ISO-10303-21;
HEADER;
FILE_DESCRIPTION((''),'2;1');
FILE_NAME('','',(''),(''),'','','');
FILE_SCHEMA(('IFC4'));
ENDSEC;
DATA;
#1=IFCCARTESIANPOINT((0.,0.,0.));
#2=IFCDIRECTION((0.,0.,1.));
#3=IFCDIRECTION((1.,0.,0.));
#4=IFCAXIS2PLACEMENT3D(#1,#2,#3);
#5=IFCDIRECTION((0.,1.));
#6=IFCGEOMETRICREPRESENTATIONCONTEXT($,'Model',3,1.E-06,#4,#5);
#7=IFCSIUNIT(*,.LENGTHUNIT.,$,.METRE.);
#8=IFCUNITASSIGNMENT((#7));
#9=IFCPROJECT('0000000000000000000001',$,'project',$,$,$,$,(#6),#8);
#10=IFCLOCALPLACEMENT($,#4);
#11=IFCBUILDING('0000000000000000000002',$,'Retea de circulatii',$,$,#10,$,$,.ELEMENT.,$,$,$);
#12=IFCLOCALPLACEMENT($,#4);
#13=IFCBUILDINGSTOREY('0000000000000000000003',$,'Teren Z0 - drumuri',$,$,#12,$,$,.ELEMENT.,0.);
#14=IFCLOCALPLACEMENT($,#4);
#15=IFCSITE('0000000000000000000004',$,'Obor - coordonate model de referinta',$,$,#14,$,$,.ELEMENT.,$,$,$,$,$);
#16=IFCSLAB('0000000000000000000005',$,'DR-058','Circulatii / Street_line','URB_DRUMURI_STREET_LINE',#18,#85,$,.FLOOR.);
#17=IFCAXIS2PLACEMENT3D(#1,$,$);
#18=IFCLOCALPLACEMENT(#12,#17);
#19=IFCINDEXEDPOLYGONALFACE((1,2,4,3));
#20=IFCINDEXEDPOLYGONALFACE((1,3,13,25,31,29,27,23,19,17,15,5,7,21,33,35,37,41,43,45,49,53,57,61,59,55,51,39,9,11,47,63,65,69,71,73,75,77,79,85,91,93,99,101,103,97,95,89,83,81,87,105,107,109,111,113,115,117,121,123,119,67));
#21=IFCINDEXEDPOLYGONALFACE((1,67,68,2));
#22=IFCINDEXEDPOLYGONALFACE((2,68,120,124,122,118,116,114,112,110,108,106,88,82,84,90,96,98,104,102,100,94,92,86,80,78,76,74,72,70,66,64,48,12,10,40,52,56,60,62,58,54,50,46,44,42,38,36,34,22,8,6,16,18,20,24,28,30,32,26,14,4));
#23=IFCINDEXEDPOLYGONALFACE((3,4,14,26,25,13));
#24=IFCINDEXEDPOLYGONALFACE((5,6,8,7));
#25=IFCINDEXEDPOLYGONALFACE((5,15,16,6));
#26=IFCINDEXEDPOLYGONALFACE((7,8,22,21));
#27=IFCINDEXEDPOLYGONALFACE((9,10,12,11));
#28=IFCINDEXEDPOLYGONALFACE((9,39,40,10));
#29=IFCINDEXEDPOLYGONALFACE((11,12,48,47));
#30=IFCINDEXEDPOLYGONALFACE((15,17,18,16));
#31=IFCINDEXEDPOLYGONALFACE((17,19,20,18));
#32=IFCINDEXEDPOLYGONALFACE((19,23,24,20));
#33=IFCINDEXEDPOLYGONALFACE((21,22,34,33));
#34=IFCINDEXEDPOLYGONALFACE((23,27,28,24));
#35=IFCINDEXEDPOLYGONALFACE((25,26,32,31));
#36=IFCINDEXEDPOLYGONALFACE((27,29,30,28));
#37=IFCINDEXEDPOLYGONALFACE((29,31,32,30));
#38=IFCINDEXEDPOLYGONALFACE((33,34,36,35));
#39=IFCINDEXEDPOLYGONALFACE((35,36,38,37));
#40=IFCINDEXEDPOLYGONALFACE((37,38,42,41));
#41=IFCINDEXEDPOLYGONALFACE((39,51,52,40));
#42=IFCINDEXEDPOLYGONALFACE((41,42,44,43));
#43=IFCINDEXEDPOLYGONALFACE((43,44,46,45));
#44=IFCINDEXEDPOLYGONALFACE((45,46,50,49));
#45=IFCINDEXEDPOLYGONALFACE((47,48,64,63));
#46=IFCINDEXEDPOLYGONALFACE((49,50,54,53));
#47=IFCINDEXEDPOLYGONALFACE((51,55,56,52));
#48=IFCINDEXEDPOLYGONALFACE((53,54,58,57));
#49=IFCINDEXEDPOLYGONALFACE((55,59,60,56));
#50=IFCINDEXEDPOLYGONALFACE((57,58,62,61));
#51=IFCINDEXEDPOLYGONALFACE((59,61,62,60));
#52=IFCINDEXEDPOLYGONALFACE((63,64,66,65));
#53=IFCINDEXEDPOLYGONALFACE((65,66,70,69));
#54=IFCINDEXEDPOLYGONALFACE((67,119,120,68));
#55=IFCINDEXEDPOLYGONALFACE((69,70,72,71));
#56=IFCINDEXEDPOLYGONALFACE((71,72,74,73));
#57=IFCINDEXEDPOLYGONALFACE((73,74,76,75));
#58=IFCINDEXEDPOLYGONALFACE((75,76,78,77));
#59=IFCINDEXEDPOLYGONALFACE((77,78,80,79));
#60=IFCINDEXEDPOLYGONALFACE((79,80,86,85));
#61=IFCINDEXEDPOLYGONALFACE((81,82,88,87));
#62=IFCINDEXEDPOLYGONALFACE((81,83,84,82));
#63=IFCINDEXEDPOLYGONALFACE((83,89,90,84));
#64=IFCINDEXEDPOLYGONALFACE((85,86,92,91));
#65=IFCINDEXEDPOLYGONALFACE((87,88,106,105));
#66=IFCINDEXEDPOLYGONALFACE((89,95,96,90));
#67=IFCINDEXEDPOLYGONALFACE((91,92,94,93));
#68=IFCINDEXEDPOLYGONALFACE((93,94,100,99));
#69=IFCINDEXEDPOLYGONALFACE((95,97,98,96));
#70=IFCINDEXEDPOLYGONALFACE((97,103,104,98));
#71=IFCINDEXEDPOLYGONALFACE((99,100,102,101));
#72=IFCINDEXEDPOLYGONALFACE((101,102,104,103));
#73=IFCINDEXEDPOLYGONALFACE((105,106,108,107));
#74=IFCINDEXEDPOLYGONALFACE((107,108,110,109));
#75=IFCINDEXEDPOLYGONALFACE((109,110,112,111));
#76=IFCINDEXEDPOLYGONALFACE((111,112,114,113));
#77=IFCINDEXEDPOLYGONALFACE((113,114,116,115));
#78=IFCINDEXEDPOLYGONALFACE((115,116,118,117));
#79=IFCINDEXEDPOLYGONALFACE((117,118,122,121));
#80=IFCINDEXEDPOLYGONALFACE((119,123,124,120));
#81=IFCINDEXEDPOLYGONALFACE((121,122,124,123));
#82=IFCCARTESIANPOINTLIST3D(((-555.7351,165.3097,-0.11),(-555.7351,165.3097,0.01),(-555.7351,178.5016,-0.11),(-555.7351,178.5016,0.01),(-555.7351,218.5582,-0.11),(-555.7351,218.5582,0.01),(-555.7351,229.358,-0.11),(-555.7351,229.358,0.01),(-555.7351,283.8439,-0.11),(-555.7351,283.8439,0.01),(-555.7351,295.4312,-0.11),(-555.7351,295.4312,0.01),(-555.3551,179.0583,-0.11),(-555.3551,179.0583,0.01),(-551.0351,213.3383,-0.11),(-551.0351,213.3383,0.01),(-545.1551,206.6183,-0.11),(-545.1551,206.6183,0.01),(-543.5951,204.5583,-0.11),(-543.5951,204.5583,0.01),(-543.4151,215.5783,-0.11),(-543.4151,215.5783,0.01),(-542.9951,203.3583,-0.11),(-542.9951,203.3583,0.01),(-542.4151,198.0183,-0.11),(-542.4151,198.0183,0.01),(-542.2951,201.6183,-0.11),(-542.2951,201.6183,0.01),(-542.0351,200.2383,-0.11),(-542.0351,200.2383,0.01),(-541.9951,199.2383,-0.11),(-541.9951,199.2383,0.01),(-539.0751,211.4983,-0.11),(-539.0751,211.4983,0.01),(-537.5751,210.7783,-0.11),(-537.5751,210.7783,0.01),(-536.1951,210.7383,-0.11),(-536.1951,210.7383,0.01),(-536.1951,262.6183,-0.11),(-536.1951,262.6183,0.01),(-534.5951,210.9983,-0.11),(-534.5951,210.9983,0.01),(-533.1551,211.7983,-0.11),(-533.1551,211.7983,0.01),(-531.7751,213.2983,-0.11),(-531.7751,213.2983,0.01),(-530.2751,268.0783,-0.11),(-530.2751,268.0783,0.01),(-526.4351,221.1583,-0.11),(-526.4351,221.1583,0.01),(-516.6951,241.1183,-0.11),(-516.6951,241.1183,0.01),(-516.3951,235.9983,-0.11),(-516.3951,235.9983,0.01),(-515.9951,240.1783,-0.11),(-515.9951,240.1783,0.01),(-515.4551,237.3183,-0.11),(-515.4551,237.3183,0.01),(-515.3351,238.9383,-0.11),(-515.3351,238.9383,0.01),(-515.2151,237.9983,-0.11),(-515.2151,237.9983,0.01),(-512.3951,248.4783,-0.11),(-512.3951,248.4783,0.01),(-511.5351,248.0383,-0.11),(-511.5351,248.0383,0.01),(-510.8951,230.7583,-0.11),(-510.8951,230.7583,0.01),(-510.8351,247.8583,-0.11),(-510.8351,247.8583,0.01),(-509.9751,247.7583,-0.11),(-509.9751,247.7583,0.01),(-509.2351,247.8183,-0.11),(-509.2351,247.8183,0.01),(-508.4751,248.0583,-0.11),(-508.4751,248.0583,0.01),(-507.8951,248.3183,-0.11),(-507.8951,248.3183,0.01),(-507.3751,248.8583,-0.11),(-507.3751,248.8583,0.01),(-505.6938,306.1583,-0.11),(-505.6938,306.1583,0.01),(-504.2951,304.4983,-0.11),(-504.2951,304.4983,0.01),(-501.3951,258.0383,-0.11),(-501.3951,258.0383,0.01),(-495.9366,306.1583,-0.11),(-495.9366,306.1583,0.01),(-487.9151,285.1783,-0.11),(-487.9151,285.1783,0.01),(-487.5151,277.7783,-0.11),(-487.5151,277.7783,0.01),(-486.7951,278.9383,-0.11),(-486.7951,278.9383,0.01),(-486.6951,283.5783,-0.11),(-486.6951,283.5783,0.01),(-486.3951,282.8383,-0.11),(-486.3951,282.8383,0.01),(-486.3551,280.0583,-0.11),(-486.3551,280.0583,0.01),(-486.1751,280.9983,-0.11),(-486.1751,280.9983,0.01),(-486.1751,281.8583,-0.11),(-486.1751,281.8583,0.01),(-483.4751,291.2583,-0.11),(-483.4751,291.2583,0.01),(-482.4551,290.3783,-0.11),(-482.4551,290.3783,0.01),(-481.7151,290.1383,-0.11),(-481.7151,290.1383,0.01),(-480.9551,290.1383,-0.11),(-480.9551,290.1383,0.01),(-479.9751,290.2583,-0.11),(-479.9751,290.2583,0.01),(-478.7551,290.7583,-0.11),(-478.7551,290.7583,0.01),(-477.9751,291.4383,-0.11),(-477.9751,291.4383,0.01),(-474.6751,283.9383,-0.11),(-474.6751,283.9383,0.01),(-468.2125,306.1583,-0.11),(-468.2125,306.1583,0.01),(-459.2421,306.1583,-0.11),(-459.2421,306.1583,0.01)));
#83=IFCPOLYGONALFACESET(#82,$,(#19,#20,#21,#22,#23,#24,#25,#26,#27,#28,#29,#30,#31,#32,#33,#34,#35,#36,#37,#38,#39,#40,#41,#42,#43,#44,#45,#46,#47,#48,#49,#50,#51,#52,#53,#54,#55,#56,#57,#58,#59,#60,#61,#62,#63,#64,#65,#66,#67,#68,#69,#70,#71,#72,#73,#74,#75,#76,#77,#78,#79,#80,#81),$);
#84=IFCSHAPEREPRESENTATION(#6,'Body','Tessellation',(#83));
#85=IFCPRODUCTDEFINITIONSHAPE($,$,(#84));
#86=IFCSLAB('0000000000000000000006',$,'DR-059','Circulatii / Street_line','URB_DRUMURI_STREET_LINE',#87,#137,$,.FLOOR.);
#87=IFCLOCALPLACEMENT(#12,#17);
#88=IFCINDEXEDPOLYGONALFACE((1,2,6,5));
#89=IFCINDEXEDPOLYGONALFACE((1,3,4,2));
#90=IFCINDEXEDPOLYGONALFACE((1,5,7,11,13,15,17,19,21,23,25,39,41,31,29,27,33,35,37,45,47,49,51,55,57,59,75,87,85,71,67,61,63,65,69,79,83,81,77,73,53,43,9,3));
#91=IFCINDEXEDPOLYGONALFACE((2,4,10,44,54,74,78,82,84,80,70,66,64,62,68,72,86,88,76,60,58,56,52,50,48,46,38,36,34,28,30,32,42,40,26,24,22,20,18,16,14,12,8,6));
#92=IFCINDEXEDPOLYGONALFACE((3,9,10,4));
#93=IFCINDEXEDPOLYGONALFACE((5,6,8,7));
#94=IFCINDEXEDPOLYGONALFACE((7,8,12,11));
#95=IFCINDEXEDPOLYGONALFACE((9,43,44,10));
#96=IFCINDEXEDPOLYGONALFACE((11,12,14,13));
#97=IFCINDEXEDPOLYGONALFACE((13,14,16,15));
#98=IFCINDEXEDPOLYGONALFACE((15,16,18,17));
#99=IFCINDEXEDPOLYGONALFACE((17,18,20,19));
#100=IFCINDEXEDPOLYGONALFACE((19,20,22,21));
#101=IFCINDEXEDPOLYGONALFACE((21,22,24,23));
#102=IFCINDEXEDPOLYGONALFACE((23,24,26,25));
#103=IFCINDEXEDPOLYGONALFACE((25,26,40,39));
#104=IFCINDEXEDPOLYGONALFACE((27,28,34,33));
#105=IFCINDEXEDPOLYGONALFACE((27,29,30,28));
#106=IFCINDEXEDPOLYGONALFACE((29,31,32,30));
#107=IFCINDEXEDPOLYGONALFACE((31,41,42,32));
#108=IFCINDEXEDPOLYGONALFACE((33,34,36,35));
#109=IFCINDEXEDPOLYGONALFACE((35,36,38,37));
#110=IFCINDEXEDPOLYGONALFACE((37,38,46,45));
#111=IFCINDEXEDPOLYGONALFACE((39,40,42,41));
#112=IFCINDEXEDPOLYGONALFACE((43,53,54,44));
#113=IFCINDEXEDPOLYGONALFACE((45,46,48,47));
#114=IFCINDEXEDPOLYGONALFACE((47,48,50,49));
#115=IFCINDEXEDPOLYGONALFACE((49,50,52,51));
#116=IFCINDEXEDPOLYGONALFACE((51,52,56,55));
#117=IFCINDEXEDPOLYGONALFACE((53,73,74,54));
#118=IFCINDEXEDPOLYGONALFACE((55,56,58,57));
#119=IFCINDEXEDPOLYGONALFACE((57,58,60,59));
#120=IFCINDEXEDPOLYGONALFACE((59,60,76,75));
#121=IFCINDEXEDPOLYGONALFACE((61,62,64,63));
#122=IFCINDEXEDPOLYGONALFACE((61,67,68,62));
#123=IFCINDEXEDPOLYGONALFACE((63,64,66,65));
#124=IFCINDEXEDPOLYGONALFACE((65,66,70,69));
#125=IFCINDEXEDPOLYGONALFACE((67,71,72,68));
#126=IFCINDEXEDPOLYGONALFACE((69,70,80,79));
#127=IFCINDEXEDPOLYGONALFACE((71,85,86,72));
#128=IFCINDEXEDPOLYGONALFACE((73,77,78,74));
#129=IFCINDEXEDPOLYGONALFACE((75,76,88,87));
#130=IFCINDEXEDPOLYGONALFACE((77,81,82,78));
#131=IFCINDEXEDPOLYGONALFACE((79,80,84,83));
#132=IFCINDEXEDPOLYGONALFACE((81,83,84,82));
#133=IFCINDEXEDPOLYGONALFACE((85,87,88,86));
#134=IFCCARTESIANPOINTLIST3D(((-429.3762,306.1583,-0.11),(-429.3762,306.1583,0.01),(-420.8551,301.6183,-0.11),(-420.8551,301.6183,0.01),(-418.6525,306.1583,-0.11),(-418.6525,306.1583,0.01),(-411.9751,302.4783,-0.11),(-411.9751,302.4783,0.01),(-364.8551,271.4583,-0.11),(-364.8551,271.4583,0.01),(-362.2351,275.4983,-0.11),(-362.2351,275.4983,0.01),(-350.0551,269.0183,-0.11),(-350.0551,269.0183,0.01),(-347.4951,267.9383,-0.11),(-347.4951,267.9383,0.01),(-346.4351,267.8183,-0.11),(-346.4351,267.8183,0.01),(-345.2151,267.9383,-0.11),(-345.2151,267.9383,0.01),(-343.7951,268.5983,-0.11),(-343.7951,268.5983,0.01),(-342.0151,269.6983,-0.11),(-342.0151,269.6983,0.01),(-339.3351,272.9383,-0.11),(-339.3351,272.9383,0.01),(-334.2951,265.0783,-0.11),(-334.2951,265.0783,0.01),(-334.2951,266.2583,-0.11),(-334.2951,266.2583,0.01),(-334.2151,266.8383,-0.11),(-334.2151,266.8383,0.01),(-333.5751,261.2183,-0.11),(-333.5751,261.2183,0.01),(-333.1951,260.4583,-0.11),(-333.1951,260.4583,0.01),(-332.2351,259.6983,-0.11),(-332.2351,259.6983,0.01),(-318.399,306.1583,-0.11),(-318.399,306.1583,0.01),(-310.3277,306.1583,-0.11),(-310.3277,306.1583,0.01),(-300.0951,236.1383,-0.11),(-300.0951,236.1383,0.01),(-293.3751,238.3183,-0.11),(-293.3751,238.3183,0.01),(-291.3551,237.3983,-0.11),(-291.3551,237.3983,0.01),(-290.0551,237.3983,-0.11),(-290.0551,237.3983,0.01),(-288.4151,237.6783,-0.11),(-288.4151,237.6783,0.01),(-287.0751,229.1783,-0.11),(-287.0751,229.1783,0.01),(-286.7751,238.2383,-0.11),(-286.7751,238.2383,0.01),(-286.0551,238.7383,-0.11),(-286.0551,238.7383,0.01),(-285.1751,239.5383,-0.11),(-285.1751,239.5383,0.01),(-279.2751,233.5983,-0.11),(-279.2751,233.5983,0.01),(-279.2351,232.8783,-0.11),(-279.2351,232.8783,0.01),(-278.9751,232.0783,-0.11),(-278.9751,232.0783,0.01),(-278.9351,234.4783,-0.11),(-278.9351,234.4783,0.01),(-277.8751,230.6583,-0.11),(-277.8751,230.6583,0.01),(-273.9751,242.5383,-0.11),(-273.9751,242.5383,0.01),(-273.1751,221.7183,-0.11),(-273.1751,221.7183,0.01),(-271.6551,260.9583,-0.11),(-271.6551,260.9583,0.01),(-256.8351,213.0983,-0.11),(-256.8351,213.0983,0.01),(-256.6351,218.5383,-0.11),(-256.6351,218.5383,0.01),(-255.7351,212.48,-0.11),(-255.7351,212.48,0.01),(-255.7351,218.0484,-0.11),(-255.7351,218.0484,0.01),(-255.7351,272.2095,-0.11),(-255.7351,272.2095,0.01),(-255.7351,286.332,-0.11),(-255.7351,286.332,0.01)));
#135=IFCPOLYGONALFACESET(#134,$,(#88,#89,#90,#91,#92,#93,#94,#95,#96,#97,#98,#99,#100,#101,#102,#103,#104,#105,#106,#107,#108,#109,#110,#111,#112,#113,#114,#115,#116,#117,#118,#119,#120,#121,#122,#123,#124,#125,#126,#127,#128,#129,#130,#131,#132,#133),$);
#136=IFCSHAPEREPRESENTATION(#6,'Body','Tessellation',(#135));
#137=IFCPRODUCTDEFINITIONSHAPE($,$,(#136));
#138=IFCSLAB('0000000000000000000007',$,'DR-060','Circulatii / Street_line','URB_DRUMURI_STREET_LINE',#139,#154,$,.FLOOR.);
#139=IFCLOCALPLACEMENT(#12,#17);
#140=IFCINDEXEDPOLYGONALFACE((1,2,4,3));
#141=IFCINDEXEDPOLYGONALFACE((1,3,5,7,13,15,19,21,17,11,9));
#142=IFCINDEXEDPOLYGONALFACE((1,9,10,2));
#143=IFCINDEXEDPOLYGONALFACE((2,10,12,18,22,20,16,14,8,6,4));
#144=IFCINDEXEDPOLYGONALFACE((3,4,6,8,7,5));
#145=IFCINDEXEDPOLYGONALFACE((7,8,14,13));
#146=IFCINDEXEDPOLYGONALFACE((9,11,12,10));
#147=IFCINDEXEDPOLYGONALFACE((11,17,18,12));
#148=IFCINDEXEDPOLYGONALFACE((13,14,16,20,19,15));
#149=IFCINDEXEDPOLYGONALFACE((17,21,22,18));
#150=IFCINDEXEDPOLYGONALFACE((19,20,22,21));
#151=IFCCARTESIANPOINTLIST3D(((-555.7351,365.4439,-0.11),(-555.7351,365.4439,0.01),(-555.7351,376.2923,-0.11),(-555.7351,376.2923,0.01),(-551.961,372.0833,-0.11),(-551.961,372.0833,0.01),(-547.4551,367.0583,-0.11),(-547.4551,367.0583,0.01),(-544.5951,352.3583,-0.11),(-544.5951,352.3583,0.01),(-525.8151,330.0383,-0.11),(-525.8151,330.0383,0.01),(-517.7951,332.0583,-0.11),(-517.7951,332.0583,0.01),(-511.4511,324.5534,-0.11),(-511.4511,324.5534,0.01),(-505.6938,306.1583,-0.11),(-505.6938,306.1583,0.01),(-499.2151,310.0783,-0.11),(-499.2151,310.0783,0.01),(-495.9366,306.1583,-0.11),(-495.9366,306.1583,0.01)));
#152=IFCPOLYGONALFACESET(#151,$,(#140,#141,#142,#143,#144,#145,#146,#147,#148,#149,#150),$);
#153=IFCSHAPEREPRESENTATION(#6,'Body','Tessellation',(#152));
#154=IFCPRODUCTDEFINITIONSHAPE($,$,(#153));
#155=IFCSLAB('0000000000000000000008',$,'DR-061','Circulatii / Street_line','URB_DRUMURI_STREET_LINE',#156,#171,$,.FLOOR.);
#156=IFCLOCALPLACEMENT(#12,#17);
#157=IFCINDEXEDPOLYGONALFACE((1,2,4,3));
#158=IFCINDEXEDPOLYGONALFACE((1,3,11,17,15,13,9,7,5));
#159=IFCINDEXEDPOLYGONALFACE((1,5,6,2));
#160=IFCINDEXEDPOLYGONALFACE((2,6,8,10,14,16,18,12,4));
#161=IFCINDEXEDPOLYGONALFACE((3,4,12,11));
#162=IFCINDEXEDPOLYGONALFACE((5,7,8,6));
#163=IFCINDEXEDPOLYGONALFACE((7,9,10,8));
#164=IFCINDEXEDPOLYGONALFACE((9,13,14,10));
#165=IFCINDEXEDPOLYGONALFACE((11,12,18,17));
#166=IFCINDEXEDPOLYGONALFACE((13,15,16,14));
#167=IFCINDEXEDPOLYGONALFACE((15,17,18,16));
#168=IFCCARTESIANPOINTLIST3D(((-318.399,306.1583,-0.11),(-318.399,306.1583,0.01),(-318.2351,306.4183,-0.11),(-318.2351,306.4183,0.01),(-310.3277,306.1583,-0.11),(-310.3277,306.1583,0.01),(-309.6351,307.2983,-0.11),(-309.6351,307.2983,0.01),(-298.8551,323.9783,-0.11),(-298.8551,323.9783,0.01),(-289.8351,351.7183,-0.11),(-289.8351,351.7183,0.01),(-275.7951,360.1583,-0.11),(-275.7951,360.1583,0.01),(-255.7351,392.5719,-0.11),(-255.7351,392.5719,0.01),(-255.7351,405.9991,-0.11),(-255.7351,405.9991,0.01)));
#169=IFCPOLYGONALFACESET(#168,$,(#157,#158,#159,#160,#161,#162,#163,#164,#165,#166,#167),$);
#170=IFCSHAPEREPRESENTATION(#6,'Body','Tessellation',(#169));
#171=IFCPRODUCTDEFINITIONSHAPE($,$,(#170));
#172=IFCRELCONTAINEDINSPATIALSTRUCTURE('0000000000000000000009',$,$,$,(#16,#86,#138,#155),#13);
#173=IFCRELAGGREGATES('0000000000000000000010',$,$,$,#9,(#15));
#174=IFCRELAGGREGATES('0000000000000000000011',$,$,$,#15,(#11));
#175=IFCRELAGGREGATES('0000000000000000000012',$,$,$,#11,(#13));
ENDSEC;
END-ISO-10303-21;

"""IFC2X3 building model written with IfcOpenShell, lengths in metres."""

from ifc_helpers import new_model, si_unit, direction, frame, origin_with_axes, place, context, project, spatial, polyline, outline, extrude, element, save


model = new_model("IFC2X3")

# Units and contexts
model_context = context("Model", 3, precision=1e-06, world=origin_with_axes(), true_north=direction((0.0, 1.0)))
ifc_project = project(units=[si_unit("LENGTHUNIT", "METRE")], contexts=[model_context])

# Site, building, storey
site_placement = place(None, origin_with_axes())
site = spatial("IfcSite", under=ifc_project, at=site_placement, Name="Obor - coordonate model de referinta", CompositionType="ELEMENT")
building_placement = place(None, origin_with_axes())
building = spatial("IfcBuilding", under=site, at=building_placement, Name="Retea de circulatii", CompositionType="ELEMENT")
storey_placement = place(None, origin_with_axes())
storey = spatial("IfcBuildingStorey", under=building, at=storey_placement, Name="Teren Z0 - drumuri", CompositionType="ELEMENT", Elevation=0.0)

# Slabs
slab_1_placement = place(None, origin_with_axes())
element("IfcSlab", 1, at=slab_1_placement, inside=storey, Name="DR-058", Description="Circulatii / Street_line", ObjectType="URB_DRUMURI_STREET_LINE", PredefinedType="FLOOR", context=model_context, shape_type="SweptSolid", body=[
    extrude(outline(polyline([(-541.9951, 199.2383), (-542.4151, 198.0183), (-555.3551, 179.0583), (-555.7351, 178.5016), (-555.7351, 165.3097), (-510.8951, 230.7583), (-474.6751, 283.9383), (-459.2421, 306.1583), (-468.2125, 306.1583), (-477.9751, 291.4383), (-478.7551, 290.7583), (-479.9751, 290.2583), (-480.9551, 290.1383), (-481.7151, 290.1383), (-482.4551, 290.3783), (-483.4751, 291.2583), (-495.9366, 306.1583), (-505.6938, 306.1583), (-504.2951, 304.4983), (-487.9151, 285.1783), (-486.6951, 283.5783), (-486.3951, 282.8383), (-486.1751, 281.8583), (-486.1751, 280.9983), (-486.3551, 280.0583), (-486.7951, 278.9383), (-487.5151, 277.7783), (-501.3951, 258.0383), (-507.3751, 248.8583), (-507.8951, 248.3183), (-508.4751, 248.0583), (-509.2351, 247.8183), (-509.9751, 247.7583), (-510.8351, 247.8583), (-511.5351, 248.0383), (-512.3951, 248.4783), (-530.2751, 268.0783), (-555.7351, 295.4312), (-555.7351, 283.8439), (-536.1951, 262.6183), (-516.6951, 241.1183), (-515.9951, 240.1783), (-515.3351, 238.9383), (-515.2151, 237.9983), (-515.4551, 237.3183), (-516.3951, 235.9983), (-526.4351, 221.1583), (-531.7751, 213.2983), (-533.1551, 211.7983), (-534.5951, 210.9983), (-536.1951, 210.7383), (-537.5751, 210.7783), (-539.0751, 211.4983), (-543.4151, 215.5783), (-555.7351, 229.358), (-555.7351, 218.5582), (-551.0351, 213.3383), (-545.1551, 206.6183), (-543.5951, 204.5583), (-542.9951, 203.3583), (-542.2951, 201.6183), (-542.0351, 200.2383), (-541.9951, 199.2383)])), frame((0.0, 0.0, -0.11), z_axis=(0.0, 0.0, 1.0), x_axis=(1.0, 0.0, 0.0)), (0.0, 0.0, 1.0), 0.12),
])
slab_2_placement = place(None, origin_with_axes())
element("IfcSlab", 2, at=slab_2_placement, inside=storey, Name="DR-059", Description="Circulatii / Street_line", ObjectType="URB_DRUMURI_STREET_LINE", PredefinedType="FLOOR", context=model_context, shape_type="SweptSolid", body=[
    extrude(outline(polyline([(-350.0551, 269.0183), (-362.2351, 275.4983), (-411.9751, 302.4783), (-418.6525, 306.1583), (-429.3762, 306.1583), (-420.8551, 301.6183), (-364.8551, 271.4583), (-300.0951, 236.1383), (-287.0751, 229.1783), (-273.1751, 221.7183), (-256.8351, 213.0983), (-255.7351, 212.48), (-255.7351, 218.0484), (-256.6351, 218.5383), (-277.8751, 230.6583), (-278.9751, 232.0783), (-279.2351, 232.8783), (-279.2751, 233.5983), (-278.9351, 234.4783), (-273.9751, 242.5383), (-255.7351, 272.2095), (-255.7351, 286.332), (-271.6551, 260.9583), (-285.1751, 239.5383), (-286.0551, 238.7383), (-286.7751, 238.2383), (-288.4151, 237.6783), (-290.0551, 237.3983), (-291.3551, 237.3983), (-293.3751, 238.3183), (-332.2351, 259.6983), (-333.1951, 260.4583), (-333.5751, 261.2183), (-334.2951, 265.0783), (-334.2951, 266.2583), (-334.2151, 266.8383), (-310.3277, 306.1583), (-318.399, 306.1583), (-339.3351, 272.9383), (-342.0151, 269.6983), (-343.7951, 268.5983), (-345.2151, 267.9383), (-346.4351, 267.8183), (-347.4951, 267.9383), (-350.0551, 269.0183)])), frame((0.0, 0.0, -0.11), z_axis=(0.0, 0.0, 1.0), x_axis=(1.0, 0.0, 0.0)), (0.0, 0.0, 1.0), 0.12),
])
slab_3_placement = place(None, origin_with_axes())
element("IfcSlab", 3, at=slab_3_placement, inside=storey, Name="DR-060", Description="Circulatii / Street_line", ObjectType="URB_DRUMURI_STREET_LINE", PredefinedType="FLOOR", context=model_context, shape_type="SweptSolid", body=[
    extrude(outline(polyline([(-544.5951, 352.3583), (-525.8151, 330.0383), (-505.6938, 306.1583), (-495.9366, 306.1583), (-499.2151, 310.0783), (-511.4511, 324.5534), (-517.7951, 332.0583), (-547.4551, 367.0583), (-551.961, 372.0833), (-555.7351, 376.2923), (-555.7351, 365.4439), (-544.5951, 352.3583)])), frame((0.0, 0.0, -0.11), z_axis=(0.0, 0.0, 1.0), x_axis=(1.0, 0.0, 0.0)), (0.0, 0.0, 1.0), 0.12),
])
slab_4_placement = place(None, origin_with_axes())
element("IfcSlab", 4, at=slab_4_placement, inside=storey, Name="DR-061", Description="Circulatii / Street_line", ObjectType="URB_DRUMURI_STREET_LINE", PredefinedType="FLOOR", context=model_context, shape_type="SweptSolid", body=[
    extrude(outline(polyline([(-255.7351, 405.9991), (-289.8351, 351.7183), (-318.2351, 306.4183), (-318.399, 306.1583), (-310.3277, 306.1583), (-309.6351, 307.2983), (-298.8551, 323.9783), (-275.7951, 360.1583), (-255.7351, 392.5719), (-255.7351, 405.9991)])), frame((0.0, 0.0, -0.11), z_axis=(0.0, 0.0, 1.0), x_axis=(1.0, 0.0, 0.0)), (0.0, 0.0, 1.0), 0.12),
])

save(model, "model.ifc")
